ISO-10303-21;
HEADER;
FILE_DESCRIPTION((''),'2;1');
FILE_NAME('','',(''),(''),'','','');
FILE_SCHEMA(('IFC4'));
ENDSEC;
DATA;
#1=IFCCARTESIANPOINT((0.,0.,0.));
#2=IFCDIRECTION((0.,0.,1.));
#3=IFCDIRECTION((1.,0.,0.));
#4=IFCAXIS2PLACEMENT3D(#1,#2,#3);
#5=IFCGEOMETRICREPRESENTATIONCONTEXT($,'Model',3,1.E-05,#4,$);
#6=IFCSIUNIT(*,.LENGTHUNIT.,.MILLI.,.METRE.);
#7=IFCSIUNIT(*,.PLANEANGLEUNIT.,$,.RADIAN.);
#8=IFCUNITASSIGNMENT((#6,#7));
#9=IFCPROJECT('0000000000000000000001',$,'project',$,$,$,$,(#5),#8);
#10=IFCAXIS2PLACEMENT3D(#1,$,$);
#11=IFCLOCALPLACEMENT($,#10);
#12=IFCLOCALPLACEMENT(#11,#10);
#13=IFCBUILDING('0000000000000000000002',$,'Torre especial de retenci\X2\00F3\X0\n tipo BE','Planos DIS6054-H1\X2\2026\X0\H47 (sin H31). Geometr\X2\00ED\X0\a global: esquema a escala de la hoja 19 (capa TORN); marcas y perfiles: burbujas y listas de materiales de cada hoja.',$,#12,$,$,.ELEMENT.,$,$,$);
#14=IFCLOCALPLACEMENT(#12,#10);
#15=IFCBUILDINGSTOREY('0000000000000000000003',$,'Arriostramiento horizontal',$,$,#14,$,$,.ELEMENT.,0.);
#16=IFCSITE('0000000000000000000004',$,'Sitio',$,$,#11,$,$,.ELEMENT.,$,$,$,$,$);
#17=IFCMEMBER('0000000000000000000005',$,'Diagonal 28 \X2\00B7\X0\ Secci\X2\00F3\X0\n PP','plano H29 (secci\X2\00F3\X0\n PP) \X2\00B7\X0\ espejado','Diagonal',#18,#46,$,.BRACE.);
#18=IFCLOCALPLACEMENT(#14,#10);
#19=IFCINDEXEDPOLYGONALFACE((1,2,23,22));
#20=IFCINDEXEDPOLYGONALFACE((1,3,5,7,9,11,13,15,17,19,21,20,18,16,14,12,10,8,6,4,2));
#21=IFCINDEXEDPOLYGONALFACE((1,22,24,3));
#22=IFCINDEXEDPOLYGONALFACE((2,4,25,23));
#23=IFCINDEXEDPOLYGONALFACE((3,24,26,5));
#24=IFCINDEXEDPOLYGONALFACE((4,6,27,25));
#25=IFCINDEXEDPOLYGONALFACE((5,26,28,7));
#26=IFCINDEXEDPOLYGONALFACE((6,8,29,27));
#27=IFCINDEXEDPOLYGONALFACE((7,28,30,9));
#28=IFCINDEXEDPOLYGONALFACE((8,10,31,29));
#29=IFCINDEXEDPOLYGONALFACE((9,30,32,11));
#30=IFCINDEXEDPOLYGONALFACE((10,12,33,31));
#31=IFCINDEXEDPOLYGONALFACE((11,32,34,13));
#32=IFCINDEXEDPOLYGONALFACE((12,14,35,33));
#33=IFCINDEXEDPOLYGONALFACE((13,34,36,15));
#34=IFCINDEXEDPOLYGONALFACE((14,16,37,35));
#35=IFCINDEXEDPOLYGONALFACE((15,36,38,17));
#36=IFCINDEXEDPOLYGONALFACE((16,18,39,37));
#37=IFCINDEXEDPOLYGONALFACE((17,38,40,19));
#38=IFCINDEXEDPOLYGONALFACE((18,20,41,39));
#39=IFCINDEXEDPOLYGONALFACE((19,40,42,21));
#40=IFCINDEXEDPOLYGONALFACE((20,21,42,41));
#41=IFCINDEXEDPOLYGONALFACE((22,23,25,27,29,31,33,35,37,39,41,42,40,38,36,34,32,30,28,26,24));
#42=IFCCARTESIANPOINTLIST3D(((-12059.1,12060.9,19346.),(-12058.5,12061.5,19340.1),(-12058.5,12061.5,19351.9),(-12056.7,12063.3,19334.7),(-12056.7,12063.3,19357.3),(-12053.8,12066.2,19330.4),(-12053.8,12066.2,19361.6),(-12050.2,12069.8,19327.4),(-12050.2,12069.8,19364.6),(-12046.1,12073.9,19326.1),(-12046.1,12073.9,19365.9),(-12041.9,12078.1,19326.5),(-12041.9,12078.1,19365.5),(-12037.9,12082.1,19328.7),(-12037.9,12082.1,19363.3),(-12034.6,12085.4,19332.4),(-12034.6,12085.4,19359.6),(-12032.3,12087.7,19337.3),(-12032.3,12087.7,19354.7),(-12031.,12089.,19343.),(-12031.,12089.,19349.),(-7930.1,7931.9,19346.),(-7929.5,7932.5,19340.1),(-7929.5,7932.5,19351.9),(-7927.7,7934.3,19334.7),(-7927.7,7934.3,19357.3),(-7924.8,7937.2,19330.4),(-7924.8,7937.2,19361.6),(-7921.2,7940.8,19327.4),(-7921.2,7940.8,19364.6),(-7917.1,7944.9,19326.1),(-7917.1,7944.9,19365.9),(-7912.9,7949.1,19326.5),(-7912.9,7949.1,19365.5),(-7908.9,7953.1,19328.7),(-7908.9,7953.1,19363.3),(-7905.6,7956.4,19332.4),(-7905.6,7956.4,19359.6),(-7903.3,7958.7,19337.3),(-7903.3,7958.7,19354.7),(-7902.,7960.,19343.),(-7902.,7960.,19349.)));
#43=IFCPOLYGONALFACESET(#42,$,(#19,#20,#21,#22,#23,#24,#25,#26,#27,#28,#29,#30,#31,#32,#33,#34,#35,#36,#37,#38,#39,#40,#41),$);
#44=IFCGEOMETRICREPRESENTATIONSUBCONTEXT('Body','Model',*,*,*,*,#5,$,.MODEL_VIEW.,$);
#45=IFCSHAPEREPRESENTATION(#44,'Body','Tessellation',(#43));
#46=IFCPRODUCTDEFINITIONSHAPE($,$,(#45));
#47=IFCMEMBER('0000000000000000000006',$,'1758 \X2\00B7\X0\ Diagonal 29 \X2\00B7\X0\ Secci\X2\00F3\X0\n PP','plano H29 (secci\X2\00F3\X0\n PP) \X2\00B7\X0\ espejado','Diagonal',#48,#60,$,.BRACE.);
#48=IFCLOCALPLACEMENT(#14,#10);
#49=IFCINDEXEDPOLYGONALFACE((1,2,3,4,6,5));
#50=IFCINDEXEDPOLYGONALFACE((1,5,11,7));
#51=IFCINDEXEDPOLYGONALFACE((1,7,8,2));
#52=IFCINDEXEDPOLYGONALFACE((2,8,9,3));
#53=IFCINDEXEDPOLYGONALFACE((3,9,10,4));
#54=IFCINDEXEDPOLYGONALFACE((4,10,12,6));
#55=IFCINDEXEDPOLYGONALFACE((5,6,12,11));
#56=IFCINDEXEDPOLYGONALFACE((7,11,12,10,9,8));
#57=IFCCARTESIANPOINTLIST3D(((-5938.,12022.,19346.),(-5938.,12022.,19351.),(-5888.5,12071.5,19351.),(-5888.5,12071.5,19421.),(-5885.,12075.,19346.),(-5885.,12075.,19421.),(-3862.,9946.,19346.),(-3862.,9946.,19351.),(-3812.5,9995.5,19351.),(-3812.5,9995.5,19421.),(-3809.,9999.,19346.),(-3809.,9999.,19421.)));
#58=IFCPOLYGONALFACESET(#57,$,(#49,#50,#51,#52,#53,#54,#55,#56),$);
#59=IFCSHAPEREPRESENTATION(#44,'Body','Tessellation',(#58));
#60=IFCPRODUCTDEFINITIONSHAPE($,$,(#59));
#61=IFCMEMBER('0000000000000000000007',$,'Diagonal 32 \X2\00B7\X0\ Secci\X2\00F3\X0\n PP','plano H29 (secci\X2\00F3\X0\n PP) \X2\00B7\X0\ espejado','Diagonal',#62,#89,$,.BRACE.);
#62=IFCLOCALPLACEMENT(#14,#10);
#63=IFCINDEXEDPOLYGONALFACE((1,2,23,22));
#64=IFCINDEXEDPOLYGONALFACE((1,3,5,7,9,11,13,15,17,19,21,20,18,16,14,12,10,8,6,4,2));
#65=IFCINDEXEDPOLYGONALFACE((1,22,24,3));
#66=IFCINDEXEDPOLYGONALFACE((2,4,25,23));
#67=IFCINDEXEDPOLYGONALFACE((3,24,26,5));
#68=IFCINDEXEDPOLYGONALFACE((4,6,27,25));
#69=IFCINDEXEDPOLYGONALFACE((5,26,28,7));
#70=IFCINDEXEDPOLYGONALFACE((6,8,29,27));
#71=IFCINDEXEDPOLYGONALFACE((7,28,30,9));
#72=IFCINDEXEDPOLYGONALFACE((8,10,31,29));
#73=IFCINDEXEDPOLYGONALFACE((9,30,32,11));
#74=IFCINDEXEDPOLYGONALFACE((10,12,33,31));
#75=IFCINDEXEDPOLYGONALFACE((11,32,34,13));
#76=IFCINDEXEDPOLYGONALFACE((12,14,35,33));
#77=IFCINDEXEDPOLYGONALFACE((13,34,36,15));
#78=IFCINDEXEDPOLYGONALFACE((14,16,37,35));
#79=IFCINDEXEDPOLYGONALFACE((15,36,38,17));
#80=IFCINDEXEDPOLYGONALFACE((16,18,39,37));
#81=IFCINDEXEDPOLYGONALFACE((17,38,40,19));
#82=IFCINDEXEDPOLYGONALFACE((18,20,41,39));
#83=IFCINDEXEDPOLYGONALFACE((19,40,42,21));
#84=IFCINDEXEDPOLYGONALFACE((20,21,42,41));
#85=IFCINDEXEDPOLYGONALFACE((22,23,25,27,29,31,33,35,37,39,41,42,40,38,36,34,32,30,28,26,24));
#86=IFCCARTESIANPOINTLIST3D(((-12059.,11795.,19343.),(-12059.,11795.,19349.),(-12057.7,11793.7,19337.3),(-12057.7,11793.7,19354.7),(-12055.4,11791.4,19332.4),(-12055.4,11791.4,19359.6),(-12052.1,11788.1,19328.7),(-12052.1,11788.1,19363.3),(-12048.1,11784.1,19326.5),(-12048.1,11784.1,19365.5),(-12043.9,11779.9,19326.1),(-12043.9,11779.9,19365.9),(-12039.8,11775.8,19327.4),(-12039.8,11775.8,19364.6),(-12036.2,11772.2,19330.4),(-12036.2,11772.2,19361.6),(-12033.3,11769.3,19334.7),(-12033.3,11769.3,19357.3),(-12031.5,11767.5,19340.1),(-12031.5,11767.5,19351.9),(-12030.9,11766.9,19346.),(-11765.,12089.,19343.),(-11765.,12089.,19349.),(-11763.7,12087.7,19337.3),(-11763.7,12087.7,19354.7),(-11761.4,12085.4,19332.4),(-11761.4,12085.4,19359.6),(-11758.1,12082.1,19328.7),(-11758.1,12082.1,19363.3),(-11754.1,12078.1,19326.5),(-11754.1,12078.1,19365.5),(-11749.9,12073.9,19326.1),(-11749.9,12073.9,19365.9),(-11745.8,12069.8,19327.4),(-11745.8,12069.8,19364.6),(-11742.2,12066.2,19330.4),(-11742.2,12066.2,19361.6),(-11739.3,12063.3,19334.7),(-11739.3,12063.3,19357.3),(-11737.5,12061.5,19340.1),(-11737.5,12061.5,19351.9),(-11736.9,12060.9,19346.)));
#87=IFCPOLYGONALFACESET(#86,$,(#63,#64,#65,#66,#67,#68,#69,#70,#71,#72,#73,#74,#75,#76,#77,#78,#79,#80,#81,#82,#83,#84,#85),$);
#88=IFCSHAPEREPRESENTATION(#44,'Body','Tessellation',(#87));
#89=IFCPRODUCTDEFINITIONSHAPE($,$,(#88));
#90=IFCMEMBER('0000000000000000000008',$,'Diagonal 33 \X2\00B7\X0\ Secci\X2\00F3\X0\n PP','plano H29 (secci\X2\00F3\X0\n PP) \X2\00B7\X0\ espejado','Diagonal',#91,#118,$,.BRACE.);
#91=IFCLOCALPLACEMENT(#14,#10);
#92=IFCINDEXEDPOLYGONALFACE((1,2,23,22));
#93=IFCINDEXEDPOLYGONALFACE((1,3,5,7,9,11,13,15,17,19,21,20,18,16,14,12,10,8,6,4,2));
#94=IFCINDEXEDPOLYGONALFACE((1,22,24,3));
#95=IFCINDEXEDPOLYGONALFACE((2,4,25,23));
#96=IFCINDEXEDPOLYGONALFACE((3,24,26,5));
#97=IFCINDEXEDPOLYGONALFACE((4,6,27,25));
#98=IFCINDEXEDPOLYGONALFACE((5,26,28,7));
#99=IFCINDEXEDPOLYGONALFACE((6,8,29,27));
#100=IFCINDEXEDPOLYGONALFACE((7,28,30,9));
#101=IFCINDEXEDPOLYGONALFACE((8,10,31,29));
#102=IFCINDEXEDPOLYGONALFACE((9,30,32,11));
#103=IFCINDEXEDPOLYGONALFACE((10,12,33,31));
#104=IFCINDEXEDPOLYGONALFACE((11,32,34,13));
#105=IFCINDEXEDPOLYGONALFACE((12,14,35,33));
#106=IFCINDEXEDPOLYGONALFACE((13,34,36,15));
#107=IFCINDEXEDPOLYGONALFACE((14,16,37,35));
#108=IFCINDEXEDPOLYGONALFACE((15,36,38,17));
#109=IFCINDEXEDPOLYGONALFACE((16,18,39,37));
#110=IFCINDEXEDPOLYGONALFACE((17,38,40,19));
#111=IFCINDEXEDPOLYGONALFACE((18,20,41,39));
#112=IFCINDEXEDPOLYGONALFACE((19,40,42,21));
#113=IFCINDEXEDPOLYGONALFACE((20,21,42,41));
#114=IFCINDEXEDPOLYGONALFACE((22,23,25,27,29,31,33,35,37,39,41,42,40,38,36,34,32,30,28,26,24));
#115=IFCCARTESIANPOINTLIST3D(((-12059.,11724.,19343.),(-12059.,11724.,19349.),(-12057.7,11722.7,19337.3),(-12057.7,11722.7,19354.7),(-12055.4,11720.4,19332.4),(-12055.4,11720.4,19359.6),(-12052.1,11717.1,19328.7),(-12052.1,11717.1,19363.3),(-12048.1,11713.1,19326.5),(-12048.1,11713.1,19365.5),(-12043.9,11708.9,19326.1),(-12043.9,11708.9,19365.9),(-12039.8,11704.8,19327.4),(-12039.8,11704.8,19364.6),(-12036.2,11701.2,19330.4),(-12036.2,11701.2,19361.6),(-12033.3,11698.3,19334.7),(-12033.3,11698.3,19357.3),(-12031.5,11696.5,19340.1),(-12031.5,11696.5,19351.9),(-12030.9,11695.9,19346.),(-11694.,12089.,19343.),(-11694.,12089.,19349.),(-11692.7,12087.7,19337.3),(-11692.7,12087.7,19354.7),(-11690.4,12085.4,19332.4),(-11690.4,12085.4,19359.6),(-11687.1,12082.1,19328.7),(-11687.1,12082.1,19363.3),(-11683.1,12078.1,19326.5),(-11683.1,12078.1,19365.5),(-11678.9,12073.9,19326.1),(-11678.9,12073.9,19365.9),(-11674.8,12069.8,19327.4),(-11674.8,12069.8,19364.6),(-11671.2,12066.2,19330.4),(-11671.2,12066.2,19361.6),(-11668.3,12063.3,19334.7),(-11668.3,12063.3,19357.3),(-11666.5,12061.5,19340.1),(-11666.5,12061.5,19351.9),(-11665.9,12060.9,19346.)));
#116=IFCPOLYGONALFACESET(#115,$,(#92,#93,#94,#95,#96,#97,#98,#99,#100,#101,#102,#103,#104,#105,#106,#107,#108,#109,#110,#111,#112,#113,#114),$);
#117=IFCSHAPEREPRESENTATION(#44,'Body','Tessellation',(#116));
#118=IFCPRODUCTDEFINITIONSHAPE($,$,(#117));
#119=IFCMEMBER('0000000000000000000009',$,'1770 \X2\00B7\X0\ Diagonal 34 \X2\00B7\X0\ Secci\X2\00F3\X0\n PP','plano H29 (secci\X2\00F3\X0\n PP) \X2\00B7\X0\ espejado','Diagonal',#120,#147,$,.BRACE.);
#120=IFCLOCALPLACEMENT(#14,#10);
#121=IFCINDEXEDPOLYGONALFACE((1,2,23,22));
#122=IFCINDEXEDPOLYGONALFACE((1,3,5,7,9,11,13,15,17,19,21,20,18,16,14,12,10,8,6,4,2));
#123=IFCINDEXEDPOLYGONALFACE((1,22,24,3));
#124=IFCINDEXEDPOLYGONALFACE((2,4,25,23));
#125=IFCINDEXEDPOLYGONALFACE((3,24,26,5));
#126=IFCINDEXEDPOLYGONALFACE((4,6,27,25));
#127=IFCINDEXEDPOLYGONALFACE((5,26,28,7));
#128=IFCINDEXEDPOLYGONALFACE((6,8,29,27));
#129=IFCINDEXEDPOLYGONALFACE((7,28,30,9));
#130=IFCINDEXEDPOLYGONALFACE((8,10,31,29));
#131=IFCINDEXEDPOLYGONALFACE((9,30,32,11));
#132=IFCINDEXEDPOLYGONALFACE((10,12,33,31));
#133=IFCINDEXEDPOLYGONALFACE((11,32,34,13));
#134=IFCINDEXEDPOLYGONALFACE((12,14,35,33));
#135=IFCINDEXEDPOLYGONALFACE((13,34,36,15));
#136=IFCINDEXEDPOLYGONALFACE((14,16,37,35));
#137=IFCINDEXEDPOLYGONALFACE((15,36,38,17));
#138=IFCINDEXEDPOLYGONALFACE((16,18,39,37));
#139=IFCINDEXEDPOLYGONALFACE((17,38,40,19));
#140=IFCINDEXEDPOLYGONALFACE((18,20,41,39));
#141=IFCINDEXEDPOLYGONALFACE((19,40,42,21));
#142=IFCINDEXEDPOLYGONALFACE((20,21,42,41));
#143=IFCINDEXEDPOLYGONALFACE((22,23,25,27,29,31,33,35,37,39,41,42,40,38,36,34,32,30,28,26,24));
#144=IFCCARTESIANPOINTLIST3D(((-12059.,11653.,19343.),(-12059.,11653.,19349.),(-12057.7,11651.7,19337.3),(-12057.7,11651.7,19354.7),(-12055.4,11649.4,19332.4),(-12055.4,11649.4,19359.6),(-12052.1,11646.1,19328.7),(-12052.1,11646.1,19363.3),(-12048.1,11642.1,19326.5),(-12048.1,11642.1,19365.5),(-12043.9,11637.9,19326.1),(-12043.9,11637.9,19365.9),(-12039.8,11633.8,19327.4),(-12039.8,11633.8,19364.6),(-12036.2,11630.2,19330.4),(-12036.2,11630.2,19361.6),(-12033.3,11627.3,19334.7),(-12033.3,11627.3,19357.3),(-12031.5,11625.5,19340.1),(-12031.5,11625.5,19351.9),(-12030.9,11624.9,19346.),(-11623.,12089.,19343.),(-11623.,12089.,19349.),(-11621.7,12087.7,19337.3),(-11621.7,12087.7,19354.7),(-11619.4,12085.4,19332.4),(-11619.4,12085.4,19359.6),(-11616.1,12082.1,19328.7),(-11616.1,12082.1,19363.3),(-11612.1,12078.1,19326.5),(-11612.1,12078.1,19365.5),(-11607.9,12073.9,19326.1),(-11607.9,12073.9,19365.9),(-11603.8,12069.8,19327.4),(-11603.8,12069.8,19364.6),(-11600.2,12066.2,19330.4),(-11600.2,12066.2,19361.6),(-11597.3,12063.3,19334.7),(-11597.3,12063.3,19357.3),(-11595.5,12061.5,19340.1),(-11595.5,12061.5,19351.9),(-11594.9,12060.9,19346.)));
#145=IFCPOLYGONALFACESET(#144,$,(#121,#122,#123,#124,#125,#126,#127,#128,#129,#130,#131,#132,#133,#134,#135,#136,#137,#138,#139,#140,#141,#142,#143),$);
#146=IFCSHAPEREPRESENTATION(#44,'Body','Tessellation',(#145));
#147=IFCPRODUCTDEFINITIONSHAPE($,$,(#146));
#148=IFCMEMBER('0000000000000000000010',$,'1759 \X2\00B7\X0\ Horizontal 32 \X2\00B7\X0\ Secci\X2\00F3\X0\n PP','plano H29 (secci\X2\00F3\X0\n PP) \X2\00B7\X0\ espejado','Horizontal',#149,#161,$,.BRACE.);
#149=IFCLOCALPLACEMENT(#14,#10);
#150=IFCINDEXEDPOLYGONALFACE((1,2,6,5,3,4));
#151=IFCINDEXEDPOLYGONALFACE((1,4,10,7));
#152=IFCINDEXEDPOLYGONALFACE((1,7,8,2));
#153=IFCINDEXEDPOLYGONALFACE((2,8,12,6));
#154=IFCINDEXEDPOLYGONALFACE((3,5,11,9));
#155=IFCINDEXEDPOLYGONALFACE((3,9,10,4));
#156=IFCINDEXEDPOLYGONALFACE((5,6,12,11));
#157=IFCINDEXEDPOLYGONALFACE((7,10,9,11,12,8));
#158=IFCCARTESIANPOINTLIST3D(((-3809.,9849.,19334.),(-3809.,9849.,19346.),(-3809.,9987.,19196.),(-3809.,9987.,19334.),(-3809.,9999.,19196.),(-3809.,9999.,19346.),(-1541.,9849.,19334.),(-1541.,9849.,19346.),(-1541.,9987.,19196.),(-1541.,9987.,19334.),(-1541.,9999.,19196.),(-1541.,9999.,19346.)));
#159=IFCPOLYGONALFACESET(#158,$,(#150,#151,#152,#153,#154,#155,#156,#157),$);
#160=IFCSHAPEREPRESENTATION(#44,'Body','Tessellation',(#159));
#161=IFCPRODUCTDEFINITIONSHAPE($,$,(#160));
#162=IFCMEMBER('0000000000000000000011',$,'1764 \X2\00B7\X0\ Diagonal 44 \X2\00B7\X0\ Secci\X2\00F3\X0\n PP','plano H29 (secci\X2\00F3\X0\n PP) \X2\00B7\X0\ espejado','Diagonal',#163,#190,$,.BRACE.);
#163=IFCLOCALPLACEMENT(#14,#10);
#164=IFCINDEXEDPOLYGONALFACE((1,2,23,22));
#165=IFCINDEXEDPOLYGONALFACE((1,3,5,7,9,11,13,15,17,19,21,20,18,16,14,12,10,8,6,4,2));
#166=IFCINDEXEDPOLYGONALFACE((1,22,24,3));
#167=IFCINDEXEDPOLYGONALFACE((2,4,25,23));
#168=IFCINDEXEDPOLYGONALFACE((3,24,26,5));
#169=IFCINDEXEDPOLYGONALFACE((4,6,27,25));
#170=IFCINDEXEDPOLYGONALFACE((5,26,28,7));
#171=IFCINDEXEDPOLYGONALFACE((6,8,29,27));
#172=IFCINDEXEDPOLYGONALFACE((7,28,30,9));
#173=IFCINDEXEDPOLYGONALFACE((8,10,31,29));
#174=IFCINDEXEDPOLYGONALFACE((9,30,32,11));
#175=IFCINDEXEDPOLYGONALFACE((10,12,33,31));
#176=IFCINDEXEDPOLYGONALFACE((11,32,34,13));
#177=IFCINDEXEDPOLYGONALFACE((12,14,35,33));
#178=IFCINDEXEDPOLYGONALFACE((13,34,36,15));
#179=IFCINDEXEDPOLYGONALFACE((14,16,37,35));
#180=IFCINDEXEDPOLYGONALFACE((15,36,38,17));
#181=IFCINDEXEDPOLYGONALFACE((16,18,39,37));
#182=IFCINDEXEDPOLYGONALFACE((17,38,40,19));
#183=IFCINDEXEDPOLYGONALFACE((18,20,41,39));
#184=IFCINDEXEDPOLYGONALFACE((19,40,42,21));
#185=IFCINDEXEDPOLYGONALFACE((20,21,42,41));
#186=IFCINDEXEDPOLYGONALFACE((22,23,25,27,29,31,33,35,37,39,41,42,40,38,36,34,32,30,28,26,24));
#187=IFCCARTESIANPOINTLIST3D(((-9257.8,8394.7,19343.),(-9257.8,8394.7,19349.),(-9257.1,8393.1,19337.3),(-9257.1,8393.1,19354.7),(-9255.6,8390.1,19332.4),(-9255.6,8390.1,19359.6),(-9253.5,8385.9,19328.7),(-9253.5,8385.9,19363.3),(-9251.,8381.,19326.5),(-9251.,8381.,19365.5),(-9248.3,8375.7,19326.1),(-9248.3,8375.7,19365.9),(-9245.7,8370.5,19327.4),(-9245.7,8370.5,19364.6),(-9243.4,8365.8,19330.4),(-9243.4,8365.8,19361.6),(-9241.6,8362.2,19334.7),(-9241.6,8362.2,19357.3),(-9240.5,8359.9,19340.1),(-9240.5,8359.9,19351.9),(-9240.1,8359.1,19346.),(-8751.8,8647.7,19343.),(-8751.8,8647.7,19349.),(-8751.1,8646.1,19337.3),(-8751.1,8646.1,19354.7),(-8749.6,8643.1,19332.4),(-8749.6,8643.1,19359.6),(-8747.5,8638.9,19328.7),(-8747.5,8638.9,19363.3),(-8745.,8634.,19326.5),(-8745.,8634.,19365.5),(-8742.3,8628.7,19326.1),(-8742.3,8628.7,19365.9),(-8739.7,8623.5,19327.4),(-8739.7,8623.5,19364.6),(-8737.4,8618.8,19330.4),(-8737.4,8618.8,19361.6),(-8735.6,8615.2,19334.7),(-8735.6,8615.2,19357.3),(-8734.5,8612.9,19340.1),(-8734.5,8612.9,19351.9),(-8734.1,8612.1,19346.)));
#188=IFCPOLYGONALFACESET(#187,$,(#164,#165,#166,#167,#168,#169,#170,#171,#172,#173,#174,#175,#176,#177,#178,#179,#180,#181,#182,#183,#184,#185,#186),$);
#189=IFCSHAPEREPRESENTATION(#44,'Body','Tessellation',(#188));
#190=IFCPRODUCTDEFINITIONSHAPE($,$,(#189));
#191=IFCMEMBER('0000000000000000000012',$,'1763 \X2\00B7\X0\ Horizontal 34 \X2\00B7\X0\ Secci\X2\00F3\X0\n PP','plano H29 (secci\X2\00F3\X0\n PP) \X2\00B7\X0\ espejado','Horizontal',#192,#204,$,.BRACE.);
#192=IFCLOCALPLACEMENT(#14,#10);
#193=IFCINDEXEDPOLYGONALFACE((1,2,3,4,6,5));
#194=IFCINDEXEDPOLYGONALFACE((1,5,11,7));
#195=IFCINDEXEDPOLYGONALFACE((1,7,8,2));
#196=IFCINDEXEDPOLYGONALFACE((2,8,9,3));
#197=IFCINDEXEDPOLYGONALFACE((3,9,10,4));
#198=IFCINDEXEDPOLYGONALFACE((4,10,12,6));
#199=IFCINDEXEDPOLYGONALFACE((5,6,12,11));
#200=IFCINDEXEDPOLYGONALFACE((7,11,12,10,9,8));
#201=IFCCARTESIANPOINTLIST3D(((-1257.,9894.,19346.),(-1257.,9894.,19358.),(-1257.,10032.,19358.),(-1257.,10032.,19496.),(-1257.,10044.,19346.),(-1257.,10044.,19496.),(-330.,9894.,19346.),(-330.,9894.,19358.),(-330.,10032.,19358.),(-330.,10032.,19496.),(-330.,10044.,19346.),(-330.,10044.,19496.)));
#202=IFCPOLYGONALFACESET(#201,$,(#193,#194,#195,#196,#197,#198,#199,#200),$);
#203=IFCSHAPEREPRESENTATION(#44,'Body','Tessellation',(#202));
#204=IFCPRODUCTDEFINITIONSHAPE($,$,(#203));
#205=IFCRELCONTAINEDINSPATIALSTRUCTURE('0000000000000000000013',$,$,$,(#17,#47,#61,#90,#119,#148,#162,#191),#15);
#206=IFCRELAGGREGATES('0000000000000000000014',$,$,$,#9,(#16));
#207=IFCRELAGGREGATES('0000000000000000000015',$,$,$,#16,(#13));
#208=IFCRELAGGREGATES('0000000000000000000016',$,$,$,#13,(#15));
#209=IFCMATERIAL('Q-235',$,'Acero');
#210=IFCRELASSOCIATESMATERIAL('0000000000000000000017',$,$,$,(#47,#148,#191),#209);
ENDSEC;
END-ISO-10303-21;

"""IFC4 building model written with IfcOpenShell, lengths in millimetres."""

from ifc_helpers import new_model, si_unit, frame, frame_2d, origin, origin_with_axes, place, context, subcontext, project, spatial, circle, l_section, extrude, material, element, save


model = new_model("IFC4")

# Units and contexts
model_context = context("Model", 3, precision=1e-05, world=origin_with_axes())
body_context = subcontext(model_context, "Body", "Model", "MODEL_VIEW")
ifc_project = project(units=[si_unit("LENGTHUNIT", "METRE", prefix="MILLI"), si_unit("PLANEANGLEUNIT", "RADIAN")], contexts=[model_context])

# Site, building, storey
site_placement = place(None, origin())
site = spatial("IfcSite", under=ifc_project, at=site_placement, Name="Sitio", CompositionType="ELEMENT")
building_placement = place(site_placement, origin())
building = spatial("IfcBuilding", under=site, at=building_placement, Name="Torre especial de retención tipo BE", Description="Planos DIS6054-H1…H47 (sin H31). Geometría global: esquema a escala de la hoja 19 (capa TORN); marcas y perfiles: burbujas y listas de materiales de cada hoja.", CompositionType="ELEMENT")
storey_placement = place(building_placement, origin())
storey = spatial("IfcBuildingStorey", under=building, at=storey_placement, Name="Arriostramiento horizontal", CompositionType="ELEMENT", Elevation=0.0)

# Members
ifc_material = material(Name="Q-235", Category="Acero")
member_1_placement = place(storey_placement, frame((-12045.0, 12075.0, 19346.0), z_axis=(0.707107, -0.707107, 0.0), x_axis=(-0.707107, -0.707107, 0.0)))
element("IfcMember", 1, at=member_1_placement, inside=storey, Name="Diagonal 28 · Sección PP", Description="plano H29 (sección PP) · espejado", ObjectType="Diagonal", PredefinedType="BRACE", context=body_context, shape_type="SweptSolid", body=[
    extrude(circle(Radius=20.0), None, (0.0, 0.0, 1.0), 5839.3),
])
member_2_placement = place(storey_placement, frame((-3809.0, 9999.0, 19346.0), z_axis=(-0.707107, 0.707107, 0.0), x_axis=(-0.707107, -0.707107, 0.0)))
element("IfcMember", 2, at=member_2_placement, inside=storey, material=ifc_material, Name="1758 · Diagonal 29 · Sección PP", Description="plano H29 (sección PP) · espejado", ObjectType="Diagonal", PredefinedType="BRACE", context=body_context, shape_type="SweptSolid", body=[
    extrude(l_section(Depth=75.0, Width=75.0, Thickness=5.0, at=frame_2d((37.5, 37.5))), None, (0.0, 0.0, 1.0), 2935.9),
])
member_3_placement = place(storey_placement, frame((-11751.0, 12075.0, 19346.0), z_axis=(-0.707107, -0.707107, 0.0), x_axis=(0.707107, -0.707107, 0.0)))
element("IfcMember", 3, at=member_3_placement, inside=storey, Name="Diagonal 32 · Sección PP", Description="plano H29 (sección PP) · espejado", ObjectType="Diagonal", PredefinedType="BRACE", context=body_context, shape_type="SweptSolid", body=[
    extrude(circle(Radius=20.0), None, (0.0, 0.0, 1.0), 415.8),
])
member_4_placement = place(storey_placement, frame((-11680.0, 12075.0, 19346.0), z_axis=(-0.707107, -0.707107, 0.0), x_axis=(0.707107, -0.707107, 0.0)))
element("IfcMember", 4, at=member_4_placement, inside=storey, Name="Diagonal 33 · Sección PP", Description="plano H29 (sección PP) · espejado", ObjectType="Diagonal", PredefinedType="BRACE", context=body_context, shape_type="SweptSolid", body=[
    extrude(circle(Radius=20.0), None, (0.0, 0.0, 1.0), 516.2),
])
member_5_placement = place(storey_placement, frame((-11609.0, 12075.0, 19346.0), z_axis=(-0.707107, -0.707107, 0.0), x_axis=(0.707107, -0.707107, 0.0)))
element("IfcMember", 5, at=member_5_placement, inside=storey, Name="1770 · Diagonal 34 · Sección PP", Description="plano H29 (sección PP) · espejado", ObjectType="Diagonal", PredefinedType="BRACE", context=body_context, shape_type="SweptSolid", body=[
    extrude(circle(Radius=20.0), None, (0.0, 0.0, 1.0), 616.6),
])
member_6_placement = place(storey_placement, frame((-3809.0, 9999.0, 19346.0), z_axis=(1.0, 0.0, 0.0), x_axis=(0.0, -1.0, 0.0)))
element("IfcMember", 6, at=member_6_placement, inside=storey, material=ifc_material, Name="1759 · Horizontal 32 · Sección PP", Description="plano H29 (sección PP) · espejado", ObjectType="Horizontal", PredefinedType="BRACE", context=body_context, shape_type="SweptSolid", body=[
    extrude(l_section(Depth=150.0, Width=150.0, Thickness=12.0, at=frame_2d((75.0, 75.0))), None, (0.0, 0.0, 1.0), 2268.0),
])
member_7_placement = place(storey_placement, frame((-8743.0, 8630.0, 19346.0), z_axis=(-0.894427, -0.447214, 0.0), x_axis=(0.447214, -0.894427, 0.0)))
element("IfcMember", 7, at=member_7_placement, inside=storey, Name="1764 · Diagonal 44 · Sección PP", Description="plano H29 (sección PP) · espejado", ObjectType="Diagonal", PredefinedType="BRACE", context=body_context, shape_type="SweptSolid", body=[
    extrude(circle(Radius=20.0), None, (0.0, 0.0, 1.0), 565.7),
])
member_8_placement = place(storey_placement, frame((-330.0, 10044.0, 19346.0), z_axis=(-1.0, 0.0, 0.0), x_axis=(0.0, -1.0, 0.0)))
element("IfcMember", 8, at=member_8_placement, inside=storey, material=ifc_material, Name="1763 · Horizontal 34 · Sección PP", Description="plano H29 (sección PP) · espejado", ObjectType="Horizontal", PredefinedType="BRACE", context=body_context, shape_type="SweptSolid", body=[
    extrude(l_section(Depth=150.0, Width=150.0, Thickness=12.0, at=frame_2d((75.0, 75.0))), None, (0.0, 0.0, 1.0), 927.0),
])

save(model, "model.ifc")
